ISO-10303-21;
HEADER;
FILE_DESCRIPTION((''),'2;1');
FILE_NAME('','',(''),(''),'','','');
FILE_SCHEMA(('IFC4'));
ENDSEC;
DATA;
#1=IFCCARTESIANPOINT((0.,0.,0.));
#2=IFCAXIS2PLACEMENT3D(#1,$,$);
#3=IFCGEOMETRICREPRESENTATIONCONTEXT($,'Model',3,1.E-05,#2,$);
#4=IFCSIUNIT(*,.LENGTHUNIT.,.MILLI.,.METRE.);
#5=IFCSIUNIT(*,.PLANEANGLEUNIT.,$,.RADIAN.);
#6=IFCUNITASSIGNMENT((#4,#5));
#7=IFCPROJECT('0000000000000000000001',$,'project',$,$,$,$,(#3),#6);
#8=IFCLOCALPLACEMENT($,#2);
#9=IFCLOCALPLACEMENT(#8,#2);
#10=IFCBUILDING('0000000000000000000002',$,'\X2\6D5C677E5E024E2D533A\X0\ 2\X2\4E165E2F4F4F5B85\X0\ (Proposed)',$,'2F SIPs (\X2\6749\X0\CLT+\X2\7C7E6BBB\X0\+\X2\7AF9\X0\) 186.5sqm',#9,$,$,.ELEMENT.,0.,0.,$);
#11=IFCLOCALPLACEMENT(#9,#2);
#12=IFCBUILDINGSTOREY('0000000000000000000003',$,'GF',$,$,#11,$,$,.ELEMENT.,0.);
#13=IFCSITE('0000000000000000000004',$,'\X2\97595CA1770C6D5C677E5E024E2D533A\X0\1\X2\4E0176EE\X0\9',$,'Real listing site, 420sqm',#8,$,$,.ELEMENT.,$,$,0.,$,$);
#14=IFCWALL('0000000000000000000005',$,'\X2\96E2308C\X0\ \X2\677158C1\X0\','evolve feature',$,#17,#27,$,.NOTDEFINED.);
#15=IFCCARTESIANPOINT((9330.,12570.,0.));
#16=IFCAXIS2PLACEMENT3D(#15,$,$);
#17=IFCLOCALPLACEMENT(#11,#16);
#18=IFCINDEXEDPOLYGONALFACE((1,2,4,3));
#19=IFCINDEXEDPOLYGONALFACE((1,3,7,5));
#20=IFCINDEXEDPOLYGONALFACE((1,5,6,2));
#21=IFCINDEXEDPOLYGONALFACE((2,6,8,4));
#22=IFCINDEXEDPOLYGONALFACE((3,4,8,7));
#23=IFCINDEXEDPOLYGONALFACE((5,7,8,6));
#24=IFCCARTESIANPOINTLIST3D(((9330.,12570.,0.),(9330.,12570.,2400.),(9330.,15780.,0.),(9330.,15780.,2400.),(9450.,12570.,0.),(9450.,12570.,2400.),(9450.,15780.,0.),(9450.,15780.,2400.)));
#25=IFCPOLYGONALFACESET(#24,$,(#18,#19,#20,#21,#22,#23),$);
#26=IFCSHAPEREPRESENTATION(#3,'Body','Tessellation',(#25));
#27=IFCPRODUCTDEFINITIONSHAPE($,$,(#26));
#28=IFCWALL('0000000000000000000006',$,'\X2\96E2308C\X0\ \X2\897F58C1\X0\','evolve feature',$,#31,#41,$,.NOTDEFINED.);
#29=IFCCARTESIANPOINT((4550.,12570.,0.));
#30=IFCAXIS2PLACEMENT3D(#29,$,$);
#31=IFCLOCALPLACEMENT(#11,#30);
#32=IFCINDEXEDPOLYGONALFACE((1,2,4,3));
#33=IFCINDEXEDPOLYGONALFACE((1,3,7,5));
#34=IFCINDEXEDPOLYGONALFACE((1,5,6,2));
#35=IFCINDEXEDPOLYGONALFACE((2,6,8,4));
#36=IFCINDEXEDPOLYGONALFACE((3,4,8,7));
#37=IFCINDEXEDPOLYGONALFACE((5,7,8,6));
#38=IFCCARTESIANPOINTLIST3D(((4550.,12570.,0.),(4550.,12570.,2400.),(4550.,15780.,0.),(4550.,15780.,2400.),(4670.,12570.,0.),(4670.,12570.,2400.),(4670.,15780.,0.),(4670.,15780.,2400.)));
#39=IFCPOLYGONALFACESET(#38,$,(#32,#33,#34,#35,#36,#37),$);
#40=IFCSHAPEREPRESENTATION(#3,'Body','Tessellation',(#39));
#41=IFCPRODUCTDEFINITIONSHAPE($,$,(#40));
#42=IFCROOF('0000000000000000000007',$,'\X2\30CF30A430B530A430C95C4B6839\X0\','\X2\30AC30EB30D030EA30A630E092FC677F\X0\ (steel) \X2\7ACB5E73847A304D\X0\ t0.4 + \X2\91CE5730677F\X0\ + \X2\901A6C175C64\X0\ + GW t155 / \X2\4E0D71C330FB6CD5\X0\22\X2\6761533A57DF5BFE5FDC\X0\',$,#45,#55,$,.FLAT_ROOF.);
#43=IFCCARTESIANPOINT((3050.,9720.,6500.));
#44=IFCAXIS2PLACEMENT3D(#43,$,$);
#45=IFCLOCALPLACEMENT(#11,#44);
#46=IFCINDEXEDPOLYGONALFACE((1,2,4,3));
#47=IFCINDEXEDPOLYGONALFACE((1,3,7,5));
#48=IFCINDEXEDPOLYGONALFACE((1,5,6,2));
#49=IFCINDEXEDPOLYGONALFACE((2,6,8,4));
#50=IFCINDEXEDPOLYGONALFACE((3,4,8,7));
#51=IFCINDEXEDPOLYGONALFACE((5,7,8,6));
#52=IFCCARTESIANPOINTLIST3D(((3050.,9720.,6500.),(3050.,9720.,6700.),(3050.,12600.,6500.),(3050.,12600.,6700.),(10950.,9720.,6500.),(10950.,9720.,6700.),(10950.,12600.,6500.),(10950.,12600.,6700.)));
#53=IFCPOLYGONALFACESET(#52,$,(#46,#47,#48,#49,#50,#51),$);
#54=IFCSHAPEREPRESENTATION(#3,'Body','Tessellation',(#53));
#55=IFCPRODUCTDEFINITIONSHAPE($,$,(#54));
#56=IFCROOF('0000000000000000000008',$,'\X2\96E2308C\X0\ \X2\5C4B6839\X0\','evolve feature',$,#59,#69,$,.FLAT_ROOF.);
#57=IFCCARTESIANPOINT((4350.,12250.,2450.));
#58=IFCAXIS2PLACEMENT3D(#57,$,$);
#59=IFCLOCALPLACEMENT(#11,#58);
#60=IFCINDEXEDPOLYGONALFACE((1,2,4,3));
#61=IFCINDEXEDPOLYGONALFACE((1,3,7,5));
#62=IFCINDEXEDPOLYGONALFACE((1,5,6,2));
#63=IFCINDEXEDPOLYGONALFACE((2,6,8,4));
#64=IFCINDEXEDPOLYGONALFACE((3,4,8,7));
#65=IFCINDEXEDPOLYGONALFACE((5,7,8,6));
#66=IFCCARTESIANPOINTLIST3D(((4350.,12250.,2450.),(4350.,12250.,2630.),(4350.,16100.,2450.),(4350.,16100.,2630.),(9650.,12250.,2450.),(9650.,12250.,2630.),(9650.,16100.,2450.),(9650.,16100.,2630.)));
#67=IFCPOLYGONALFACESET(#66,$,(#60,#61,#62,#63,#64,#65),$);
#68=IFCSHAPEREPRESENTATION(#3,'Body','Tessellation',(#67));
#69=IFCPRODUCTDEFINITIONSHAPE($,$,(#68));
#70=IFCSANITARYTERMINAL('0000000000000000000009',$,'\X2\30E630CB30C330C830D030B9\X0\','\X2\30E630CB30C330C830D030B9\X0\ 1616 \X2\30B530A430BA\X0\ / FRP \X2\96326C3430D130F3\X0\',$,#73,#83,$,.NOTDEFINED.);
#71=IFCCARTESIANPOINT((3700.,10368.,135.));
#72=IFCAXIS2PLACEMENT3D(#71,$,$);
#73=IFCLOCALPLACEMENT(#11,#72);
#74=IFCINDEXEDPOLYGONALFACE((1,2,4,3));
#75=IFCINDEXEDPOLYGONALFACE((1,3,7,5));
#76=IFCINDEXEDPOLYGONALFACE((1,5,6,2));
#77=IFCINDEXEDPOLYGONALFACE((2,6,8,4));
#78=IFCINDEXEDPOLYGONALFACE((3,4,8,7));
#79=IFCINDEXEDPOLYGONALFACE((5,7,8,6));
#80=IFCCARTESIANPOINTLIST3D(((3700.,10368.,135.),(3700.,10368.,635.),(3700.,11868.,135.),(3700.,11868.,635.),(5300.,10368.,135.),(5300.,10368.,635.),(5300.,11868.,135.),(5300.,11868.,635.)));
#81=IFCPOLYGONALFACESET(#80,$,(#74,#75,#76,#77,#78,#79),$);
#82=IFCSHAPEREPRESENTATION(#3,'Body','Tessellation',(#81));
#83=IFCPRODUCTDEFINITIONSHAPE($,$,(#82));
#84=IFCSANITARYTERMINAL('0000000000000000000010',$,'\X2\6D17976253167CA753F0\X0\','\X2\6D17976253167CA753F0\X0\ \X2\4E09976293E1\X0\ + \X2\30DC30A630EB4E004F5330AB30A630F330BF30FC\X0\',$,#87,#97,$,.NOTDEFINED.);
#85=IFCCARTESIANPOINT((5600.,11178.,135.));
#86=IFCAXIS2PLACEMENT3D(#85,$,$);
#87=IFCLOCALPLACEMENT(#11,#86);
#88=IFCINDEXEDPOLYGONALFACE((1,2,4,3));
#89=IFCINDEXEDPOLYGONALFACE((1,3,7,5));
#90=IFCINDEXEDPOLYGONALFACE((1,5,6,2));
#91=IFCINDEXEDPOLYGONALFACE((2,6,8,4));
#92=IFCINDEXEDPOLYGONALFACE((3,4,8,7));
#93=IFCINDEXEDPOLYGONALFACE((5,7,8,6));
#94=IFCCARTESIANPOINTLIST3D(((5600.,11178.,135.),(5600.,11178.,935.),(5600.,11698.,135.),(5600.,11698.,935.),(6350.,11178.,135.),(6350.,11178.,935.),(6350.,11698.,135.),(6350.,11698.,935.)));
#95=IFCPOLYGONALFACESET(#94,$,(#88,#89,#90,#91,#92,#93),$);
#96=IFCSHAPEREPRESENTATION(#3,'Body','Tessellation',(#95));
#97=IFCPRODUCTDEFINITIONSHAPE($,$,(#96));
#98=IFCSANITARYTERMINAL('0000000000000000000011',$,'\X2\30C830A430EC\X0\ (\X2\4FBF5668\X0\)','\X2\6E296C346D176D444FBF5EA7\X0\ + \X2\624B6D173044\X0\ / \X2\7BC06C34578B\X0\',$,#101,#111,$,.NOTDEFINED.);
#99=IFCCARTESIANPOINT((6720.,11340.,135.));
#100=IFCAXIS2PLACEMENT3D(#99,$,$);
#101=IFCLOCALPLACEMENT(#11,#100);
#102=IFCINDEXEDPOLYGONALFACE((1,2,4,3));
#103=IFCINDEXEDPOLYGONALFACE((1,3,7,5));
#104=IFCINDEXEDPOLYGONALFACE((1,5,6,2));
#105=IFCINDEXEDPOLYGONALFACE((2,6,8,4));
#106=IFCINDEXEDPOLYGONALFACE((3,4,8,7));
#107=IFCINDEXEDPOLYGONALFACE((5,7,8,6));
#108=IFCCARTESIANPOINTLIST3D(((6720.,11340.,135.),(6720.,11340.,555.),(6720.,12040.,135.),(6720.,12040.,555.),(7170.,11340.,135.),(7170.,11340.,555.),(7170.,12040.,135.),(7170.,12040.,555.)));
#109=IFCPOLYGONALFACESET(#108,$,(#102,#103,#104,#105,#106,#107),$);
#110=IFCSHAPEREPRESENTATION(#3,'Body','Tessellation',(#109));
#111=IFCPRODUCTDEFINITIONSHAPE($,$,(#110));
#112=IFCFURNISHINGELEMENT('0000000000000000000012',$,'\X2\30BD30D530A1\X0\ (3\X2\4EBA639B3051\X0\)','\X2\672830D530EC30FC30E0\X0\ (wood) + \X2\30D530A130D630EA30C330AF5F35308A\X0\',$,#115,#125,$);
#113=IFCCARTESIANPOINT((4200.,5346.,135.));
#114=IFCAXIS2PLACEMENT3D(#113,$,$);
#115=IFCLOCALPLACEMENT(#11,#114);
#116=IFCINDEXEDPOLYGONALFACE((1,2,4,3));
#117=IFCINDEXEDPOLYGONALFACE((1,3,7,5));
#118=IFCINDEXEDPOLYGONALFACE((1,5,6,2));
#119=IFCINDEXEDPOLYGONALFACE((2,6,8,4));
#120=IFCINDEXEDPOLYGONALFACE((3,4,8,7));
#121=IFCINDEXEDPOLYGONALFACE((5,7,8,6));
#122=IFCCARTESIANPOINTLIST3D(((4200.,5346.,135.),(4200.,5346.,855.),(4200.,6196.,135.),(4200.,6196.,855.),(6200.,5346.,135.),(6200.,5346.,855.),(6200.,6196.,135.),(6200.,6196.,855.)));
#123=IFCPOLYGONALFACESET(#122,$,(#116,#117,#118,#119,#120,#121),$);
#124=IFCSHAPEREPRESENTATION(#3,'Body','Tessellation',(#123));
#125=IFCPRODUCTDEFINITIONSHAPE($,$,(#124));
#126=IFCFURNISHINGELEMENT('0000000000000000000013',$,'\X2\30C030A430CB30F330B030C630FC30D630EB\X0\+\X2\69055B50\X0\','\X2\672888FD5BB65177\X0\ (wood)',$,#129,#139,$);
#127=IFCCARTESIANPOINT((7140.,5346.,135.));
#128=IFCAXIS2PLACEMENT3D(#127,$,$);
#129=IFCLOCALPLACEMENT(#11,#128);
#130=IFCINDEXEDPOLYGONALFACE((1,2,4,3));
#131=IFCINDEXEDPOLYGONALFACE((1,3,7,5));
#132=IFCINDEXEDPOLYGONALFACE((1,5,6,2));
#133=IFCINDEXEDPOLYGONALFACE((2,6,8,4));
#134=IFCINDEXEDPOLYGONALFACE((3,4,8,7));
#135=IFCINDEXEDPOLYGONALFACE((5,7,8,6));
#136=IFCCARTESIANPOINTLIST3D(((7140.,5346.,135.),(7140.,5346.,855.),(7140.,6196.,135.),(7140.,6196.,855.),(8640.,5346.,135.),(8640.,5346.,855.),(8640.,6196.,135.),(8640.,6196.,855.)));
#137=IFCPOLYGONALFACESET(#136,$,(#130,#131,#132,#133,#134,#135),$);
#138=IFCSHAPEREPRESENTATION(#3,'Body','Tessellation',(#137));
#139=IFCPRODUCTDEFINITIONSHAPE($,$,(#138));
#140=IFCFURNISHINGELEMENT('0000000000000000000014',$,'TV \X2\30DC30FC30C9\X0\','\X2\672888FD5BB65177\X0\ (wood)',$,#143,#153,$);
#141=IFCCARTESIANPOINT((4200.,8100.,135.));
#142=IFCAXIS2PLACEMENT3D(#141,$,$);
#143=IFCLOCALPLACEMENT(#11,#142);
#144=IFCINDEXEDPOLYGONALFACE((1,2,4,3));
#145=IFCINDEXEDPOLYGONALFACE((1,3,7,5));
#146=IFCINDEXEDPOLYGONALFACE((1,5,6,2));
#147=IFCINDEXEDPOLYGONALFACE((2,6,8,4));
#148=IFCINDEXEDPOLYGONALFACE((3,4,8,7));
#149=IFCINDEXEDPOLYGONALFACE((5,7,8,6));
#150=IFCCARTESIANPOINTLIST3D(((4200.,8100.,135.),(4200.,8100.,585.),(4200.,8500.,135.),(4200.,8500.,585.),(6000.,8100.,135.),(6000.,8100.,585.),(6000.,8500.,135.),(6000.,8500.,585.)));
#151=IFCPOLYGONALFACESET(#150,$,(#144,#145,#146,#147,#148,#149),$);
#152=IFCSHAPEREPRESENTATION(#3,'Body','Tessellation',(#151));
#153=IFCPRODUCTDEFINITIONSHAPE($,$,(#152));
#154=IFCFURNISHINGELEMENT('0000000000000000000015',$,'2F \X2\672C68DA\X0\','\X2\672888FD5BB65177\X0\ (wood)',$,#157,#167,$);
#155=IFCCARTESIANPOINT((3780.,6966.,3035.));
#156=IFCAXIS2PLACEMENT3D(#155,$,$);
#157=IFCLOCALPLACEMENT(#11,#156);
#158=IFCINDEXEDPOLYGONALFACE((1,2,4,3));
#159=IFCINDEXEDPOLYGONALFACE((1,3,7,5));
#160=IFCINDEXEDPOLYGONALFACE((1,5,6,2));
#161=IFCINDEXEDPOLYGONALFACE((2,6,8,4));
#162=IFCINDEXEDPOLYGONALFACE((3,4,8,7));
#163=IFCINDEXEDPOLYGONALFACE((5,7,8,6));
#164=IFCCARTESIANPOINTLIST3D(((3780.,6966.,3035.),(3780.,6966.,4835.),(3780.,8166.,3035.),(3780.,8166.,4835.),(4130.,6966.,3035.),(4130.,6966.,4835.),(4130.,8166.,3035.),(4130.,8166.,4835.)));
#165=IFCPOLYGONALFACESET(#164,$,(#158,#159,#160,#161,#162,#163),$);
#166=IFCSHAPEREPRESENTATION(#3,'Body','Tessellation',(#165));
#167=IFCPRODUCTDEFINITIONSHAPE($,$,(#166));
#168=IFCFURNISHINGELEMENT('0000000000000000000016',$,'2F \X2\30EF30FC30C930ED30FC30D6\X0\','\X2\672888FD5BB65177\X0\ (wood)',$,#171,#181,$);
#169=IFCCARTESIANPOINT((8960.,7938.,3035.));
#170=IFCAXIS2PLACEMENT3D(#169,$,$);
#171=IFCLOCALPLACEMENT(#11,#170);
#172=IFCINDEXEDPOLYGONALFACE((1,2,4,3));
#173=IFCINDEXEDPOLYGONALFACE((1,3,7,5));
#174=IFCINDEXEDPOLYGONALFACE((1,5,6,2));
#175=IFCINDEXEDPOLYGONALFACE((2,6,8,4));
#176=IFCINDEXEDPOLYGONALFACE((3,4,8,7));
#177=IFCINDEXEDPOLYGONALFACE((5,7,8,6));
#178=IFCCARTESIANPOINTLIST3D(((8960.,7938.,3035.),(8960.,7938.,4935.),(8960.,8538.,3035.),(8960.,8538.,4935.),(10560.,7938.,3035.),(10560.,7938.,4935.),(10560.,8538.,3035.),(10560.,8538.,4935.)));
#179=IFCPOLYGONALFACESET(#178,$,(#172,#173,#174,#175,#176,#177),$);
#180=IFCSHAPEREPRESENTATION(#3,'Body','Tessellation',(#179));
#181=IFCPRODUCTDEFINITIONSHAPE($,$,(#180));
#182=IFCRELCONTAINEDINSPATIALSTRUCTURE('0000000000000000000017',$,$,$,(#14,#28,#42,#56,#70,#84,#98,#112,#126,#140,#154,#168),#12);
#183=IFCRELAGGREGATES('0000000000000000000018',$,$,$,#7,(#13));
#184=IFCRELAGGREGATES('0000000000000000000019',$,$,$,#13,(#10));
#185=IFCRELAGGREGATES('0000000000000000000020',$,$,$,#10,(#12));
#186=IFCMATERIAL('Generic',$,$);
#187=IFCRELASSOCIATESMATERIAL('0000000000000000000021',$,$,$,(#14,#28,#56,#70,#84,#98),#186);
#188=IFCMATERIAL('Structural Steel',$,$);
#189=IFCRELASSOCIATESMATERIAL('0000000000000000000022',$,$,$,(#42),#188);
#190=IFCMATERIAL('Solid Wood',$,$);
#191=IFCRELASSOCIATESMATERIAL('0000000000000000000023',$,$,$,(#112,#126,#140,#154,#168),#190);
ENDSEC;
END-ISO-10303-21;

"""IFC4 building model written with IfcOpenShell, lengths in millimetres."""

from ifc_helpers import new_model, si_unit, frame, frame_2d, origin, place, context, project, spatial, rectangle, extrude, material, element, save


model = new_model("IFC4")

# Units and contexts
model_context = context("Model", 3, precision=1e-05, world=origin())
ifc_project = project(units=[si_unit("LENGTHUNIT", "METRE", prefix="MILLI"), si_unit("PLANEANGLEUNIT", "RADIAN")], contexts=[model_context])

# Site, building, storey
site_placement = place(None, origin())
site = spatial("IfcSite", under=ifc_project, at=site_placement, Name="静岡県浜松市中区1丁目9", ObjectType="Real listing site, 420sqm", CompositionType="ELEMENT", RefElevation=0.0)
building_placement = place(site_placement, origin())
building = spatial("IfcBuilding", under=site, at=building_placement, Name="浜松市中区 2世帯住宅 (Proposed)", ObjectType="2F SIPs (杉CLT+籾殻+竹) 186.5sqm", CompositionType="ELEMENT", ElevationOfRefHeight=0.0, ElevationOfTerrain=0.0)
storey_placement = place(building_placement, origin())
storey = spatial("IfcBuildingStorey", under=building, at=storey_placement, Name="GF", CompositionType="ELEMENT", Elevation=0.0)

# Shared definitions
ifc_material_1 = material(Name="Generic")

# Shared definitions
ifc_material_2 = material(Name="Solid Wood")

# Walls
wall_1_placement = place(storey_placement, frame((9330.0, 12570.0, 0.0)))
element("IfcWall", 1, at=wall_1_placement, inside=storey, material=ifc_material_1, Name="離れ 東壁", Description="evolve feature", PredefinedType="NOTDEFINED", context=model_context, shape_type="SweptSolid", body=[
    extrude(rectangle(XDim=120.0, YDim=3210.0, at=frame_2d((60.0, 1605.0))), frame((9330.0, 12570.0, 0.0)), (0.0, 0.0, 1.0), 2400.0),
])
wall_2_placement = place(storey_placement, frame((4550.0, 12570.0, 0.0)))
element("IfcWall", 2, at=wall_2_placement, inside=storey, material=ifc_material_1, Name="離れ 西壁", Description="evolve feature", PredefinedType="NOTDEFINED", context=model_context, shape_type="SweptSolid", body=[
    extrude(rectangle(XDim=120.0, YDim=3210.0, at=frame_2d((60.0, 1605.0))), frame((4550.0, 12570.0, 0.0)), (0.0, 0.0, 1.0), 2400.0),
])

# Roofs
ifc_material_3 = material(Name="Structural Steel")
roof_1_placement = place(storey_placement, frame((3050.0, 9720.0, 6500.0)))
element("IfcRoof", 3, at=roof_1_placement, inside=storey, material=ifc_material_3, Name="ハイサイド屋根", Description="ガルバリウム鋼板 (steel) 立平葺き t0.4 + 野地板 + 通気層 + GW t155 / 不燃・法22条区域対応", PredefinedType="FLAT_ROOF", context=model_context, shape_type="SweptSolid", body=[
    extrude(rectangle(XDim=7900.0, YDim=2880.0, at=frame_2d((3950.0, 1440.0))), frame((3050.0, 9720.0, 6500.0)), (0.0, 0.0, 1.0), 200.0),
])
roof_2_placement = place(storey_placement, frame((4350.0, 12250.0, 2450.0)))
element("IfcRoof", 4, at=roof_2_placement, inside=storey, material=ifc_material_1, Name="離れ 屋根", Description="evolve feature", PredefinedType="FLAT_ROOF", context=model_context, shape_type="SweptSolid", body=[
    extrude(rectangle(XDim=5300.0, YDim=3850.0, at=frame_2d((2650.0, 1925.0))), frame((4350.0, 12250.0, 2450.0)), (0.0, 0.0, 1.0), 180.0),
])

# Sanitary terminals
sanitary_terminal_1_placement = place(storey_placement, frame((3700.0, 10368.0, 135.0)))
element("IfcSanitaryTerminal", 5, at=sanitary_terminal_1_placement, inside=storey, material=ifc_material_1, Name="ユニットバス", Description="ユニットバス 1616 サイズ / FRP 防水パン", PredefinedType="NOTDEFINED", context=model_context, shape_type="SweptSolid", body=[
    extrude(rectangle(XDim=1600.0, YDim=1500.0, at=frame_2d((800.0, 750.0))), frame((3700.0, 10368.0, 135.0)), (0.0, 0.0, 1.0), 500.0),
])
sanitary_terminal_2_placement = place(storey_placement, frame((5600.0, 11178.0, 135.0)))
element("IfcSanitaryTerminal", 6, at=sanitary_terminal_2_placement, inside=storey, material=ifc_material_1, Name="洗面化粧台", Description="洗面化粧台 三面鏡 + ボウル一体カウンター", PredefinedType="NOTDEFINED", context=model_context, shape_type="SweptSolid", body=[
    extrude(rectangle(XDim=750.0, YDim=520.0, at=frame_2d((375.0, 260.0))), frame((5600.0, 11178.0, 135.0)), (0.0, 0.0, 1.0), 800.0),
])
sanitary_terminal_3_placement = place(storey_placement, frame((6720.0, 11340.0, 135.0)))
element("IfcSanitaryTerminal", 7, at=sanitary_terminal_3_placement, inside=storey, material=ifc_material_1, Name="トイレ (便器)", Description="温水洗浄便座 + 手洗い / 節水型", PredefinedType="NOTDEFINED", context=model_context, shape_type="SweptSolid", body=[
    extrude(rectangle(XDim=450.0, YDim=700.0, at=frame_2d((225.0, 350.0))), frame((6720.0, 11340.0, 135.0)), (0.0, 0.0, 1.0), 420.0),
])

# Furnishing elements
furnishing_1_placement = place(storey_placement, frame((4200.0, 5346.0, 135.0)))
element("IfcFurnishingElement", 8, at=furnishing_1_placement, inside=storey, material=ifc_material_2, Name="ソファ (3人掛け)", Description="木フレーム (wood) + ファブリック張り", context=model_context, shape_type="SweptSolid", body=[
    extrude(rectangle(XDim=2000.0, YDim=850.0, at=frame_2d((1000.0, 425.0))), frame((4200.0, 5346.0, 135.0)), (0.0, 0.0, 1.0), 720.0),
])
furnishing_2_placement = place(storey_placement, frame((7140.0, 5346.0, 135.0)))
element("IfcFurnishingElement", 9, at=furnishing_2_placement, inside=storey, material=ifc_material_2, Name="ダイニングテーブル+椅子", Description="木製家具 (wood)", context=model_context, shape_type="SweptSolid", body=[
    extrude(rectangle(XDim=1500.0, YDim=850.0, at=frame_2d((750.0, 425.0))), frame((7140.0, 5346.0, 135.0)), (0.0, 0.0, 1.0), 720.0),
])
furnishing_3_placement = place(storey_placement, frame((4200.0, 8100.0, 135.0)))
element("IfcFurnishingElement", 10, at=furnishing_3_placement, inside=storey, material=ifc_material_2, Name="TV ボード", Description="木製家具 (wood)", context=model_context, shape_type="SweptSolid", body=[
    extrude(rectangle(XDim=1800.0, YDim=400.0, at=frame_2d((900.0, 200.0))), frame((4200.0, 8100.0, 135.0)), (0.0, 0.0, 1.0), 450.0),
])
furnishing_4_placement = place(storey_placement, frame((3780.0, 6966.0, 3035.0)))
element("IfcFurnishingElement", 11, at=furnishing_4_placement, inside=storey, material=ifc_material_2, Name="2F 本棚", Description="木製家具 (wood)", context=model_context, shape_type="SweptSolid", body=[
    extrude(rectangle(XDim=350.0, YDim=1200.0, at=frame_2d((175.0, 600.0))), frame((3780.0, 6966.0, 3035.0)), (0.0, 0.0, 1.0), 1800.0),
])
furnishing_5_placement = place(storey_placement, frame((8960.0, 7938.0, 3035.0)))
element("IfcFurnishingElement", 12, at=furnishing_5_placement, inside=storey, material=ifc_material_2, Name="2F ワードローブ", Description="木製家具 (wood)", context=model_context, shape_type="SweptSolid", body=[
    extrude(rectangle(XDim=1600.0, YDim=600.0, at=frame_2d((800.0, 300.0))), frame((8960.0, 7938.0, 3035.0)), (0.0, 0.0, 1.0), 1900.0),
])

save(model, "model.ifc")
